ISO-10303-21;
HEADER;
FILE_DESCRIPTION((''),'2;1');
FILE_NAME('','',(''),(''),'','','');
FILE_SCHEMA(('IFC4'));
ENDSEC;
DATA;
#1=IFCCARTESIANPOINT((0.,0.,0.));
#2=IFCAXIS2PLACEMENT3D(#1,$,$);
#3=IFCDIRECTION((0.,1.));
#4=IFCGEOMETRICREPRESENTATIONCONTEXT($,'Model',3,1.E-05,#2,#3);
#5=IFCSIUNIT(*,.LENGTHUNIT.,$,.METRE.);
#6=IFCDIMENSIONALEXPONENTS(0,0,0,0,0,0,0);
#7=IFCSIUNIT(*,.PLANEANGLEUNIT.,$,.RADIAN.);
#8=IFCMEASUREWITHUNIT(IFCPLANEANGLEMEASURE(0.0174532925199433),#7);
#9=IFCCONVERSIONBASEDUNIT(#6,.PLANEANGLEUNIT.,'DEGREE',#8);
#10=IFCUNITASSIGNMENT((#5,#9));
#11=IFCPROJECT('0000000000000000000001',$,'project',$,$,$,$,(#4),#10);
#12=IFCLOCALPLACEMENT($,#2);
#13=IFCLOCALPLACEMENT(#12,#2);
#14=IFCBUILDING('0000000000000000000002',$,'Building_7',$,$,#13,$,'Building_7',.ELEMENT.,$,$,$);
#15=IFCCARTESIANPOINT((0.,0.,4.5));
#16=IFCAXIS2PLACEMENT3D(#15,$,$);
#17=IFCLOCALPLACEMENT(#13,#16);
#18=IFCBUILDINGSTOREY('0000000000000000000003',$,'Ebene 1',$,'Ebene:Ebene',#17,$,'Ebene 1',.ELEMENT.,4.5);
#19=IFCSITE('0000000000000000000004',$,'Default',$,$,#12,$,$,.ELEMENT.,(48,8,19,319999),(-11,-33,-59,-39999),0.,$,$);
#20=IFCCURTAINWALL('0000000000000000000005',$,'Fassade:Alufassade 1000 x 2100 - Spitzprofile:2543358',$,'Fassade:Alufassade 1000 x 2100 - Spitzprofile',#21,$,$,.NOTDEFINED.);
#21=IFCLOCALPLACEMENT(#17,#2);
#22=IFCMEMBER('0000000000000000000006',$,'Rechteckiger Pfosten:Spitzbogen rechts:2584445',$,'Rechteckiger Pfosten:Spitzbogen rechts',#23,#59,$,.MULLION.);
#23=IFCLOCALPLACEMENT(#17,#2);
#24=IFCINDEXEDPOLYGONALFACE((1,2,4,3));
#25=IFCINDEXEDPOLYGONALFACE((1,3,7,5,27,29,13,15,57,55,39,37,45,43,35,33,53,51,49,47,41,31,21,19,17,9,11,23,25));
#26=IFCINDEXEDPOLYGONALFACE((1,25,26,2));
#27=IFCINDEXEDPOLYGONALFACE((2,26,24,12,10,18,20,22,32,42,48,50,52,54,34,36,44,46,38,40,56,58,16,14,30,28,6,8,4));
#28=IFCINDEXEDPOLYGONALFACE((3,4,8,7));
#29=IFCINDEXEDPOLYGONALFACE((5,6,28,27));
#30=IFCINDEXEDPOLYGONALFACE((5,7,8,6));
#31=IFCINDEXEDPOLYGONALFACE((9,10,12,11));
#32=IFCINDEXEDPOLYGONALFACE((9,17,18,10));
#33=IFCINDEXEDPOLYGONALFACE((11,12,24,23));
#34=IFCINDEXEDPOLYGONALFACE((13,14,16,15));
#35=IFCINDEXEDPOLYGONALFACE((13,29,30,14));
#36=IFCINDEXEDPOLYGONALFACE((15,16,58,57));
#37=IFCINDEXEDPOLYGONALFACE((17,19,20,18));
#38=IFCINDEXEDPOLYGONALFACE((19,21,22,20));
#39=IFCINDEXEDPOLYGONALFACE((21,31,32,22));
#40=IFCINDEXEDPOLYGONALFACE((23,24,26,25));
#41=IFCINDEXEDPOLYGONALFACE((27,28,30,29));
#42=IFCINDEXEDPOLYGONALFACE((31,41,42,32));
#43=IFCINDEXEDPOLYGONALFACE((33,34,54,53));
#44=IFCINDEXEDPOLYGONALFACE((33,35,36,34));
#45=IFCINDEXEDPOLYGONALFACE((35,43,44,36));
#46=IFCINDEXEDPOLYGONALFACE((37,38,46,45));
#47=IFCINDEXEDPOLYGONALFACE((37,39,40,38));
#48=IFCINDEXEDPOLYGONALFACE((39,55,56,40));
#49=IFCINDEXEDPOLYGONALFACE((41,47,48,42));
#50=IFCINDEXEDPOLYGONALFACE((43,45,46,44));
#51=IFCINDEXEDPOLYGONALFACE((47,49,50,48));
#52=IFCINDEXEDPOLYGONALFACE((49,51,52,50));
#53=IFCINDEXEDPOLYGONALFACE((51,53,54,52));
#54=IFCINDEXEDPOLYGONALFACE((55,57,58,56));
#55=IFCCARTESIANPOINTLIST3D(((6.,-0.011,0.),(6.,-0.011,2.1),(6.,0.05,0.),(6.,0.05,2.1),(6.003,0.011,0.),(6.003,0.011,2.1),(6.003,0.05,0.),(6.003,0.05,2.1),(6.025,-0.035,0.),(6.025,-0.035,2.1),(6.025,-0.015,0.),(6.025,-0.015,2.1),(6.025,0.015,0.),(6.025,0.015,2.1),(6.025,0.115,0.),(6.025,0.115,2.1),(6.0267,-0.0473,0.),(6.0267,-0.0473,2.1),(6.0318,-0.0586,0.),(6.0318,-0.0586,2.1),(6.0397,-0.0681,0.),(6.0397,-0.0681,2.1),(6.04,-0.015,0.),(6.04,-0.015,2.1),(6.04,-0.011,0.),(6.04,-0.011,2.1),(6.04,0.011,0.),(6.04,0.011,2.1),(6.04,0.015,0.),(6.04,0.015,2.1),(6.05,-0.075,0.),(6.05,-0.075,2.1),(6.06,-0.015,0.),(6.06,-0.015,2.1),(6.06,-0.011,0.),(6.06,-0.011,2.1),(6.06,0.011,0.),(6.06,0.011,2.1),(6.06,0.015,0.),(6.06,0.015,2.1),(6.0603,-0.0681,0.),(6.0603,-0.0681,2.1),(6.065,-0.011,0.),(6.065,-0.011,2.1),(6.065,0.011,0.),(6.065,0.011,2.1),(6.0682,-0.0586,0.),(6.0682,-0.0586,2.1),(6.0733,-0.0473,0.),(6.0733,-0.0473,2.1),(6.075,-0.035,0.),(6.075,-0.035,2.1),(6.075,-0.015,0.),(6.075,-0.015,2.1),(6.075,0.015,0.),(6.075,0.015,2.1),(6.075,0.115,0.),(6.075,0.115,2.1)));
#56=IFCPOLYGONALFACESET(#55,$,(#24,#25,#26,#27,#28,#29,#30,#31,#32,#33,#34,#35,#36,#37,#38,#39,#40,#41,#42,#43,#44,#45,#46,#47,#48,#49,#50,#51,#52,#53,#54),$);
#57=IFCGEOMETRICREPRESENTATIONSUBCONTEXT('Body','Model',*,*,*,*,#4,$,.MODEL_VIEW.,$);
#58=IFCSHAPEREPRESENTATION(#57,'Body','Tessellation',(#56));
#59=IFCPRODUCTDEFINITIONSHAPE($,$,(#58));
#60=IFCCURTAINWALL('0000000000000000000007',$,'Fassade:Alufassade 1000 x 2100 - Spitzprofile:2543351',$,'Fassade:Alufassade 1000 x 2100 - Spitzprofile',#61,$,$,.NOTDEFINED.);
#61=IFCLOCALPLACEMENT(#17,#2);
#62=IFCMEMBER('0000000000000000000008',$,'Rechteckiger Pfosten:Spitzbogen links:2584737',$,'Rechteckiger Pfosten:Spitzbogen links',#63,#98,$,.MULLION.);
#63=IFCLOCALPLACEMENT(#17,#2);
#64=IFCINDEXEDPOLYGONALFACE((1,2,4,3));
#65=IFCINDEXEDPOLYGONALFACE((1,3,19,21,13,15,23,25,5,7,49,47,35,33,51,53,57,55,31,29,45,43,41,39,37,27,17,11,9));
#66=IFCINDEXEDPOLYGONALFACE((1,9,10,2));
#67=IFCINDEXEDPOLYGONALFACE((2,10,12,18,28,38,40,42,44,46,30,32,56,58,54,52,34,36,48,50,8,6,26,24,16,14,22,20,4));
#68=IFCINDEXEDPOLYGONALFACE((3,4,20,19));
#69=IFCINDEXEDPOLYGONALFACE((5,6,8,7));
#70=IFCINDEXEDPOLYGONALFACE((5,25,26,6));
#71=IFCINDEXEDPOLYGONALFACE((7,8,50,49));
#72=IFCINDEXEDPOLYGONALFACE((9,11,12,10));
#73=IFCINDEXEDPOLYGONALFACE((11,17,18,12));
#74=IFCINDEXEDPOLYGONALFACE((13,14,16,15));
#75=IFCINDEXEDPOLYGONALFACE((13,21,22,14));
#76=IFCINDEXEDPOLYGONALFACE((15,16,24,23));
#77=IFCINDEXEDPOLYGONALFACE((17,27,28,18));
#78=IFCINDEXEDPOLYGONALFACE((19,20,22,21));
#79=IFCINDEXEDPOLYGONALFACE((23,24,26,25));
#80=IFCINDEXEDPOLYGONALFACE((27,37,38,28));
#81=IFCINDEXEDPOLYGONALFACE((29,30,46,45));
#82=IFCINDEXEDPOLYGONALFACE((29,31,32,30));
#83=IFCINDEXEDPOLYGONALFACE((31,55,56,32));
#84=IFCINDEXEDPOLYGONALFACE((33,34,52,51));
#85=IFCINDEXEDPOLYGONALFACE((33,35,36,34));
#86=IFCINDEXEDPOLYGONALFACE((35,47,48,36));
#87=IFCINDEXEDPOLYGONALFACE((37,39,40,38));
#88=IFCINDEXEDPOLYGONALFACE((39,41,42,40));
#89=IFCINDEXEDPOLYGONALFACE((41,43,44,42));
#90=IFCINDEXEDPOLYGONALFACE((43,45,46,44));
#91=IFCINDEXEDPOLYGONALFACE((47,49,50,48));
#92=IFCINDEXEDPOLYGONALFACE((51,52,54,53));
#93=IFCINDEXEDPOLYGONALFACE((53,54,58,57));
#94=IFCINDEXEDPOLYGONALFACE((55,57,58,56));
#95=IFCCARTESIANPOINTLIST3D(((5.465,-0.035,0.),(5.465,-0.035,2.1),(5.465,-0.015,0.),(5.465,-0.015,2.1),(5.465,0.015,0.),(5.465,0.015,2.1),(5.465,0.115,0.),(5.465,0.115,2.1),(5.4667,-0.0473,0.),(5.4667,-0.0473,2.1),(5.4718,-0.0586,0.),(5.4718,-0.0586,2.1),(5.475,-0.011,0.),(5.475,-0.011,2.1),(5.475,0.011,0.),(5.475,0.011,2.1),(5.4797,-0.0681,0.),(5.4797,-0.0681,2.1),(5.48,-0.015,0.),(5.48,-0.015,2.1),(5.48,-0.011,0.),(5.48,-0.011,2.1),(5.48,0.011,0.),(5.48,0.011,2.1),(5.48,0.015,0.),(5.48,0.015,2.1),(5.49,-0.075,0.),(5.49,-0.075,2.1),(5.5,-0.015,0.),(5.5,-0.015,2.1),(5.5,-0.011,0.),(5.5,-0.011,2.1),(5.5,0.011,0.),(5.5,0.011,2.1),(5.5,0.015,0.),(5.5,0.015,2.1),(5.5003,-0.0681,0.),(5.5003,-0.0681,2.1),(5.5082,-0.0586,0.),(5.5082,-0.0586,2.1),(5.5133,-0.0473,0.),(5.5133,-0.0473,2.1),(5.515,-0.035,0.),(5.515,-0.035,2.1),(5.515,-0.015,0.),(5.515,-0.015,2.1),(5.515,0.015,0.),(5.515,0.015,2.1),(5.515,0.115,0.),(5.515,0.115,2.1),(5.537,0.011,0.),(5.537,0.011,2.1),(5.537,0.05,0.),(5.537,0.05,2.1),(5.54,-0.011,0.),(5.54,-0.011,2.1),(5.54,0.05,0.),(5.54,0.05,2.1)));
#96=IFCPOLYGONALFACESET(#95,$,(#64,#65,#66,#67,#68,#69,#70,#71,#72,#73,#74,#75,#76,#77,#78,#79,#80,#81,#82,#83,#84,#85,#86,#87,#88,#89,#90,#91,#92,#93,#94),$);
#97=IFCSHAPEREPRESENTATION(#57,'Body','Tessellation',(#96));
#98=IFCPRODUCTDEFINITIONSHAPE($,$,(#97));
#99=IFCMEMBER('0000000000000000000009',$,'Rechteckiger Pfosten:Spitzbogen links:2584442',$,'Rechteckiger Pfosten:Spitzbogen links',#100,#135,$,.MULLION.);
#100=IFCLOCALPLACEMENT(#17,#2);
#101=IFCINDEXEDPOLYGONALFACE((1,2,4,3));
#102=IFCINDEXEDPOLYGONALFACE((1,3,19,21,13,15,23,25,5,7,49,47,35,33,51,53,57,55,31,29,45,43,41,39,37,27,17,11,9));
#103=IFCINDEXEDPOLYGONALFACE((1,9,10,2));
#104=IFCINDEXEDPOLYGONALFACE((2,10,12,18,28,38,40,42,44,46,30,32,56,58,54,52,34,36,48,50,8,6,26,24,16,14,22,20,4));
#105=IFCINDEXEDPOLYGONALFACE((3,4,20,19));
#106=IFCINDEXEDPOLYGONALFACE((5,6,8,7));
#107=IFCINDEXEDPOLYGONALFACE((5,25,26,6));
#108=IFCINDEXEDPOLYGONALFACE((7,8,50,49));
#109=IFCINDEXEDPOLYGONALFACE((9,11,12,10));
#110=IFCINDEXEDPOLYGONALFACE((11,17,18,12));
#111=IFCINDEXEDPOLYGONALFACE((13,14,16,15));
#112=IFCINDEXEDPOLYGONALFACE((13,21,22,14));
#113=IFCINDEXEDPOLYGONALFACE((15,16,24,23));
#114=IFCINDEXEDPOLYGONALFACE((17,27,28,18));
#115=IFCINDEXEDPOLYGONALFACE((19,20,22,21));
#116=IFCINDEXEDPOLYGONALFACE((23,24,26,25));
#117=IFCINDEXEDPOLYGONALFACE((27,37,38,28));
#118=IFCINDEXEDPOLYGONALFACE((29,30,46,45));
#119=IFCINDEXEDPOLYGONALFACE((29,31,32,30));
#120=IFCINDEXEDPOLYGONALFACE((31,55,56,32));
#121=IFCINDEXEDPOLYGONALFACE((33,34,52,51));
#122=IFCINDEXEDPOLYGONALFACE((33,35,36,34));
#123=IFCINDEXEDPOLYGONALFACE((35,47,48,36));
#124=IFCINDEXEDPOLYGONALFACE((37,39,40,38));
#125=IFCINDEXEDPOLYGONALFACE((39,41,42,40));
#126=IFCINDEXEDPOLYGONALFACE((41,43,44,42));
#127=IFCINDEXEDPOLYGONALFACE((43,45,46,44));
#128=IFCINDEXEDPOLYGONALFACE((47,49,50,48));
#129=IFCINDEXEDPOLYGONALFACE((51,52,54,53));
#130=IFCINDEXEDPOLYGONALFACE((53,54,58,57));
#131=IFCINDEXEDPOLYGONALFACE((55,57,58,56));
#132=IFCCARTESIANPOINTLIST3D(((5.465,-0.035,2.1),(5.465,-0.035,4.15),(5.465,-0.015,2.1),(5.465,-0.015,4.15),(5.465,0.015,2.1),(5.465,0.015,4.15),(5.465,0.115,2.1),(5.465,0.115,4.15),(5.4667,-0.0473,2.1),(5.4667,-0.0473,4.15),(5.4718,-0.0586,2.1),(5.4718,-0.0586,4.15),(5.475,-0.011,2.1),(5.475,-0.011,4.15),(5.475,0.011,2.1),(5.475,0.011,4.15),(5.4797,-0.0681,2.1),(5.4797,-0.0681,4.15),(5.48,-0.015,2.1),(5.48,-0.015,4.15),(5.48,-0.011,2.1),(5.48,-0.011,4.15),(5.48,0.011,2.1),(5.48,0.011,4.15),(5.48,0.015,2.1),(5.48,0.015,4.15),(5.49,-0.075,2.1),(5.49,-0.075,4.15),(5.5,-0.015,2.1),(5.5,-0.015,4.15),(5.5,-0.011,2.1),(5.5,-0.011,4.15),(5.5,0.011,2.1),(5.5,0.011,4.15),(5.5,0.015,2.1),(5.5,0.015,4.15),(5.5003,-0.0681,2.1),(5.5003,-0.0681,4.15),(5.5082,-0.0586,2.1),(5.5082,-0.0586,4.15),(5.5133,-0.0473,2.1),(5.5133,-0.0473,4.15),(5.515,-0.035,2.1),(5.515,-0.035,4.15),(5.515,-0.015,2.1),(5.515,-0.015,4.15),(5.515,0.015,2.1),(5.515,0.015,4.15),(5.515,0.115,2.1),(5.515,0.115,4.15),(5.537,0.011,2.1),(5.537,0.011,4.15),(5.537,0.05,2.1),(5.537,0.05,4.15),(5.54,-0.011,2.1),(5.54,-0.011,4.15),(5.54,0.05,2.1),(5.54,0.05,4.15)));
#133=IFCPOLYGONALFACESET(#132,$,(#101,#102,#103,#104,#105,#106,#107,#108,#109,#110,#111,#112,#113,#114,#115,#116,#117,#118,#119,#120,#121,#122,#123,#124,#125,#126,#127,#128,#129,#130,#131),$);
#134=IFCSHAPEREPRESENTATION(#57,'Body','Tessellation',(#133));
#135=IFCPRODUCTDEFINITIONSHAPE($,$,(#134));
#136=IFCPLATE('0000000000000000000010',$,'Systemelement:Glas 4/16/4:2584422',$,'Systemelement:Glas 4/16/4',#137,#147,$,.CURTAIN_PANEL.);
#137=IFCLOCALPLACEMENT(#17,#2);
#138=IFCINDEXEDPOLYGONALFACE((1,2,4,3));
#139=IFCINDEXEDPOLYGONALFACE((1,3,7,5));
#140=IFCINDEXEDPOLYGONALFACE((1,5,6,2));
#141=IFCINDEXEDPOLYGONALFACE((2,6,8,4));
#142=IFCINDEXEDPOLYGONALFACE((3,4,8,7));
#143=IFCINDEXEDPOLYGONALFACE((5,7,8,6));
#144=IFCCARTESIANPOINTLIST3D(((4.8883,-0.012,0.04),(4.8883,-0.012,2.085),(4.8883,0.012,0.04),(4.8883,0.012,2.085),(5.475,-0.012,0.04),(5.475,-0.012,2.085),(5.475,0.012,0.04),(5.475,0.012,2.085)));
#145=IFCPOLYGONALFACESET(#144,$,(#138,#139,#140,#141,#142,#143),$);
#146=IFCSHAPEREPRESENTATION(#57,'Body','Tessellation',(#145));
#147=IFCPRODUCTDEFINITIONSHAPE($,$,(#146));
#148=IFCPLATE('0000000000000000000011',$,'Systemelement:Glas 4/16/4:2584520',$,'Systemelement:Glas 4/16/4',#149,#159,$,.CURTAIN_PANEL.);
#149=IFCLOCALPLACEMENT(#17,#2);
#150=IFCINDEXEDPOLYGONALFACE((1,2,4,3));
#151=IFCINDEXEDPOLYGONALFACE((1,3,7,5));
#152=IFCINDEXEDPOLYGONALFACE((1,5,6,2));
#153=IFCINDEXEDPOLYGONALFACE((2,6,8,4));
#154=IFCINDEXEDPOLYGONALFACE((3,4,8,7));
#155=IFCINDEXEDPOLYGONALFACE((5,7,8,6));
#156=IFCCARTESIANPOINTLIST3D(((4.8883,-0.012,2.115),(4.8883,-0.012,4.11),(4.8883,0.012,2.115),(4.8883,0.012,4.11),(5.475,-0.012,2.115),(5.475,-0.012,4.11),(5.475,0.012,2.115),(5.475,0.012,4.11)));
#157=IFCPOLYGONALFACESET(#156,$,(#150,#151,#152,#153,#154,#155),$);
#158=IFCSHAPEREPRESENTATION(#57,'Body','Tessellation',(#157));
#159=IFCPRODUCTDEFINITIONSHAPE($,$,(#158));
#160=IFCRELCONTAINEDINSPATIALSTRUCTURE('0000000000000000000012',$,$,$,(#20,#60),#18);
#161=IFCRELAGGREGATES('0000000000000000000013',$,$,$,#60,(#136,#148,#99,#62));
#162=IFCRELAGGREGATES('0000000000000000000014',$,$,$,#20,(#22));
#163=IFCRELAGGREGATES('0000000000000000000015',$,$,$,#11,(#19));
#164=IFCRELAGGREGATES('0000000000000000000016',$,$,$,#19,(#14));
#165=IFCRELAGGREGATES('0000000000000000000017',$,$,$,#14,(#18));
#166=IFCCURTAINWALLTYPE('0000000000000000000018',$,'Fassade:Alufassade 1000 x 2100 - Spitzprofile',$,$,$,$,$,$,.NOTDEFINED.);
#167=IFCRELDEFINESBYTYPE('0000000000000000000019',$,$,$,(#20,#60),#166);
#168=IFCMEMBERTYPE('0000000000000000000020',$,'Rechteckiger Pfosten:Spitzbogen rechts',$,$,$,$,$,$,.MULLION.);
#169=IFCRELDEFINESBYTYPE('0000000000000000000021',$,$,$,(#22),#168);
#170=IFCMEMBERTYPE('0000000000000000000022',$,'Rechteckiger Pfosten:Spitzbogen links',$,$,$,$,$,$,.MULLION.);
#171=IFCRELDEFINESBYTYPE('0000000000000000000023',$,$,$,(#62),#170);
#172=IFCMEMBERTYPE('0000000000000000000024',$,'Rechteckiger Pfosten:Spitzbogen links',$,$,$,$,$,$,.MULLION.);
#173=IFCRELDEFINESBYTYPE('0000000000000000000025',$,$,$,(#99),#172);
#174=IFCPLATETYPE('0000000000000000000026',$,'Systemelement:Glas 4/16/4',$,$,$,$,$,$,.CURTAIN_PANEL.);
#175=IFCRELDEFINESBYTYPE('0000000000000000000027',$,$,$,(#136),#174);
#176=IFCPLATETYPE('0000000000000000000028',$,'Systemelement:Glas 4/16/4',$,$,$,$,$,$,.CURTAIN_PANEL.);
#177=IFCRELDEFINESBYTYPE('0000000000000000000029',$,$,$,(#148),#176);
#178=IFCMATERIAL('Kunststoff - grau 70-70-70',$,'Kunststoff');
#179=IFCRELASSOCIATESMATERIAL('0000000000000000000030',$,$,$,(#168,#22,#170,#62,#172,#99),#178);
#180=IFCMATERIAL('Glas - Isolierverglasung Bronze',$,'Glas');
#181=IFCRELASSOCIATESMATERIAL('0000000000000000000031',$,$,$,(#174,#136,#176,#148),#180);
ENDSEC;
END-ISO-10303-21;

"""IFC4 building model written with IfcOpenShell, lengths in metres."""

from ifc_helpers import new_model, entity, si_unit, converted_unit, direction, frame, origin, place, context, subcontext, project, spatial, line, arc, indexed_curve, outline, extrude, source, transform, mapped, material, type_object, type_shapes, element, aggregate, save


model = new_model("IFC4")

# Units and contexts
model_context = context("Model", 3, precision=1e-05, world=origin(), true_north=direction((0.0, 1.0)))
body_context = subcontext(model_context, "Body", "Model", "MODEL_VIEW")
ifc_project = project(units=[si_unit("LENGTHUNIT", "METRE"), converted_unit("PLANEANGLEUNIT", "DEGREE", entity("IfcPlaneAngleMeasure", 0.0174532925199433), si_unit("PLANEANGLEUNIT", "RADIAN"), dimensions=[0, 0, 0, 0, 0, 0, 0])], contexts=[model_context])

# Site, building, storey
site_placement = place(None, origin())
site = spatial("IfcSite", under=ifc_project, at=site_placement, Name="Default", CompositionType="ELEMENT", RefLatitude=(48, 8, 19, 319999), RefLongitude=(-11, -33, -59, -39999), RefElevation=0.0)
building_placement = place(site_placement, origin())
building = spatial("IfcBuilding", under=site, at=building_placement, Name="Building_7", LongName="Building_7", CompositionType="ELEMENT")
storey_placement = place(building_placement, frame((0.0, 0.0, 4.5)))
storey = spatial("IfcBuildingStorey", under=building, at=storey_placement, Name="Ebene 1", ObjectType="Ebene:Ebene", LongName="Ebene 1", CompositionType="ELEMENT", Elevation=4.5)

# Curtain wall, member
curtain_wall_type = type_object("IfcCurtainWallType", Name="Fassade:Alufassade 1000 x 2100 - Spitzprofile", PredefinedType="NOTDEFINED")
curtain_wall_1_placement = place(storey_placement, frame((0.0, 0.0, -4.5)))
curtain_wall_1 = element("IfcCurtainWall", 1, at=curtain_wall_1_placement, inside=storey, type_object=curtain_wall_type, Name="Fassade:Alufassade 1000 x 2100 - Spitzprofile:2543358", ObjectType="Fassade:Alufassade 1000 x 2100 - Spitzprofile", PredefinedType="NOTDEFINED")
ifc_material_1 = material(Name="Kunststoff - grau 70-70-70", Category="Kunststoff")
member_type_1 = type_object("IfcMemberType", Name="Rechteckiger Pfosten:Spitzbogen rechts", PredefinedType="MULLION", material=ifc_material_1)
shared_shape_1 = source(origin(), body_context, "Body", "SweptSolid", [
    extrude(outline(indexed_curve([(-0.107, -0.0321), (-0.007, -0.0321), (-0.007, -0.0171), (-0.003, -0.0171), (-0.003, -0.0221), (0.019, -0.0221), (0.019, -0.0171), (0.023, -0.0171), (0.023, -0.0321), (0.043, -0.0321), (0.0666, -0.0254), (0.083, -0.0071), (0.0666, 0.0111), (0.043, 0.0179), (0.023, 0.0179), (0.023, 0.0029), (0.019, 0.0029), (0.019, 0.0429), (-0.042, 0.0429), (-0.042, 0.0399), (-0.003, 0.0399), (-0.003, 0.0029), (-0.007, 0.0029), (-0.007, 0.0179), (-0.107, 0.0179)], segments=[line(1, 2, 3, 4, 5, 6, 7, 8, 9, 10), arc(10, 11, 12), arc(12, 13, 14), line(14, 15, 16, 17, 18, 19, 20, 21, 22, 23, 24, 25, 1)], self_intersect=False)), frame((-0.0429, 0.008, -2.1), z_axis=(0.0, 0.0, 1.0), x_axis=(0.0, -1.0, 0.0)), (0.0, 0.0, 1.0), 2.1),
])
type_shapes(member_type_1, [shared_shape_1])
member_1_placement = place(curtain_wall_1_placement, frame((6.0, 0.0, 4.5), z_axis=(0.0, 0.0, -1.0), x_axis=(-1.0, 0.0, 0.0)))
member_1 = element("IfcMember", 2, at=member_1_placement, type_object=member_type_1, material=ifc_material_1, Name="Rechteckiger Pfosten:Spitzbogen rechts:2584445", ObjectType="Rechteckiger Pfosten:Spitzbogen rechts", PredefinedType="MULLION", context=body_context, shape_type="MappedRepresentation", body=[
    mapped(shared_shape_1, transform((0.0, 0.0, 0.0), scale=1.0)),
])

# Curtain wall, members
curtain_wall_2_placement = place(storey_placement, frame((0.0, 0.0, -4.5)))
curtain_wall_2 = element("IfcCurtainWall", 3, at=curtain_wall_2_placement, inside=storey, type_object=curtain_wall_type, Name="Fassade:Alufassade 1000 x 2100 - Spitzprofile:2543351", ObjectType="Fassade:Alufassade 1000 x 2100 - Spitzprofile", PredefinedType="NOTDEFINED")
member_type_2 = type_object("IfcMemberType", Name="Rechteckiger Pfosten:Spitzbogen links", PredefinedType="MULLION", material=ifc_material_1)
shared_shape_2 = source(origin(), body_context, "Body", "SweptSolid", [
    extrude(outline(indexed_curve([(-0.107, -0.0321), (-0.007, -0.0321), (-0.007, -0.0171), (-0.003, -0.0171), (-0.003, -0.0221), (0.019, -0.0221), (0.019, -0.0171), (0.023, -0.0171), (0.023, -0.0321), (0.043, -0.0321), (0.0666, -0.0254), (0.083, -0.0071), (0.0666, 0.0111), (0.043, 0.0179), (0.023, 0.0179), (0.023, 0.0029), (0.019, 0.0029), (0.019, 0.0429), (-0.042, 0.0429), (-0.042, 0.0399), (-0.003, 0.0399), (-0.003, 0.0029), (-0.007, 0.0029), (-0.007, 0.0179), (-0.107, 0.0179)], segments=[line(1, 2, 3, 4, 5, 6, 7, 8, 9, 10), arc(10, 11, 12), arc(12, 13, 14), line(14, 15, 16, 17, 18, 19, 20, 21, 22, 23, 24, 25, 1)], self_intersect=False)), frame((-0.0429, 0.008, -2.1), z_axis=(0.0, 0.0, 1.0), x_axis=(0.0, -1.0, 0.0)), (0.0, 0.0, 1.0), 2.1),
])
type_shapes(member_type_2, [shared_shape_2])
member_2_placement = place(curtain_wall_2_placement, frame((5.54, 0.0, 6.6)))
member_2 = element("IfcMember", 4, at=member_2_placement, type_object=member_type_2, material=ifc_material_1, Name="Rechteckiger Pfosten:Spitzbogen links:2584737", ObjectType="Rechteckiger Pfosten:Spitzbogen links", PredefinedType="MULLION", context=body_context, shape_type="MappedRepresentation", body=[
    mapped(shared_shape_2, transform((0.0, 0.0, 0.0), scale=1.0)),
])
member_type_3 = type_object("IfcMemberType", Name="Rechteckiger Pfosten:Spitzbogen links", PredefinedType="MULLION", material=ifc_material_1)
shared_shape_3 = source(origin(), body_context, "Body", "SweptSolid", [
    extrude(outline(indexed_curve([(-0.107, -0.0321), (-0.007, -0.0321), (-0.007, -0.0171), (-0.003, -0.0171), (-0.003, -0.0221), (0.019, -0.0221), (0.019, -0.0171), (0.023, -0.0171), (0.023, -0.0321), (0.043, -0.0321), (0.0666, -0.0254), (0.083, -0.0071), (0.0666, 0.0111), (0.043, 0.0179), (0.023, 0.0179), (0.023, 0.0029), (0.019, 0.0029), (0.019, 0.0429), (-0.042, 0.0429), (-0.042, 0.0399), (-0.003, 0.0399), (-0.003, 0.0029), (-0.007, 0.0029), (-0.007, 0.0179), (-0.107, 0.0179)], segments=[line(1, 2, 3, 4, 5, 6, 7, 8, 9, 10), arc(10, 11, 12), arc(12, 13, 14), line(14, 15, 16, 17, 18, 19, 20, 21, 22, 23, 24, 25, 1)], self_intersect=False)), frame((-0.0429, 0.008, -2.05), z_axis=(0.0, 0.0, 1.0), x_axis=(0.0, -1.0, 0.0)), (0.0, 0.0, 1.0), 2.05),
])
type_shapes(member_type_3, [shared_shape_3])
member_3_placement = place(curtain_wall_2_placement, frame((5.54, 0.0, 8.65)))
member_3 = element("IfcMember", 5, at=member_3_placement, type_object=member_type_3, material=ifc_material_1, Name="Rechteckiger Pfosten:Spitzbogen links:2584442", ObjectType="Rechteckiger Pfosten:Spitzbogen links", PredefinedType="MULLION", context=body_context, shape_type="MappedRepresentation", body=[
    mapped(shared_shape_3, transform((0.0, 0.0, 0.0), scale=1.0)),
])

# Plates
ifc_material_2 = material(Name="Glas - Isolierverglasung Bronze", Category="Glas")
plate_type_1 = type_object("IfcPlateType", Name="Systemelement:Glas 4/16/4", PredefinedType="CURTAIN_PANEL", material=ifc_material_2)
shared_shape_4 = source(origin(), body_context, "Body", "SweptSolid", [
    extrude(outline(indexed_curve([(-0.012, -0.2933), (0.012, -0.2933), (0.012, 0.2933), (-0.012, 0.2933), (-0.012, -0.2933)], self_intersect=False)), frame((0.0, 0.0, 0.0), z_axis=(0.0, 0.0, 1.0), x_axis=(0.0, 1.0, 0.0)), (0.0, 0.0, 1.0), 2.045),
])
type_shapes(plate_type_1, [shared_shape_4])
plate_1_placement = place(curtain_wall_2_placement, frame((5.1817, 0.0, 4.54), z_axis=(0.0, 0.0, 1.0), x_axis=(-1.0, 0.0, 0.0)))
plate_1 = element("IfcPlate", 6, at=plate_1_placement, type_object=plate_type_1, material=ifc_material_2, Name="Systemelement:Glas 4/16/4:2584422", ObjectType="Systemelement:Glas 4/16/4", PredefinedType="CURTAIN_PANEL", context=body_context, shape_type="MappedRepresentation", body=[
    mapped(shared_shape_4, transform((0.0, 0.0, 0.0), scale=1.0)),
])
plate_type_2 = type_object("IfcPlateType", Name="Systemelement:Glas 4/16/4", PredefinedType="CURTAIN_PANEL", material=ifc_material_2)
shared_shape_5 = source(origin(), body_context, "Body", "SweptSolid", [
    extrude(outline(indexed_curve([(-0.012, -0.2933), (0.012, -0.2933), (0.012, 0.2933), (-0.012, 0.2933), (-0.012, -0.2933)], self_intersect=False)), frame((0.0, 0.0, 0.0), z_axis=(0.0, 0.0, 1.0), x_axis=(0.0, 1.0, 0.0)), (0.0, 0.0, 1.0), 1.995),
])
type_shapes(plate_type_2, [shared_shape_5])
plate_2_placement = place(curtain_wall_2_placement, frame((5.1817, 0.0, 6.615), z_axis=(0.0, 0.0, 1.0), x_axis=(-1.0, 0.0, 0.0)))
plate_2 = element("IfcPlate", 7, at=plate_2_placement, type_object=plate_type_2, material=ifc_material_2, Name="Systemelement:Glas 4/16/4:2584520", ObjectType="Systemelement:Glas 4/16/4", PredefinedType="CURTAIN_PANEL", context=body_context, shape_type="MappedRepresentation", body=[
    mapped(shared_shape_5, transform((0.0, 0.0, 0.0), scale=1.0)),
])
aggregate(curtain_wall_2, [plate_1, plate_2, member_3, member_2])
aggregate(curtain_wall_1, [member_1])

save(model, "model.ifc")
